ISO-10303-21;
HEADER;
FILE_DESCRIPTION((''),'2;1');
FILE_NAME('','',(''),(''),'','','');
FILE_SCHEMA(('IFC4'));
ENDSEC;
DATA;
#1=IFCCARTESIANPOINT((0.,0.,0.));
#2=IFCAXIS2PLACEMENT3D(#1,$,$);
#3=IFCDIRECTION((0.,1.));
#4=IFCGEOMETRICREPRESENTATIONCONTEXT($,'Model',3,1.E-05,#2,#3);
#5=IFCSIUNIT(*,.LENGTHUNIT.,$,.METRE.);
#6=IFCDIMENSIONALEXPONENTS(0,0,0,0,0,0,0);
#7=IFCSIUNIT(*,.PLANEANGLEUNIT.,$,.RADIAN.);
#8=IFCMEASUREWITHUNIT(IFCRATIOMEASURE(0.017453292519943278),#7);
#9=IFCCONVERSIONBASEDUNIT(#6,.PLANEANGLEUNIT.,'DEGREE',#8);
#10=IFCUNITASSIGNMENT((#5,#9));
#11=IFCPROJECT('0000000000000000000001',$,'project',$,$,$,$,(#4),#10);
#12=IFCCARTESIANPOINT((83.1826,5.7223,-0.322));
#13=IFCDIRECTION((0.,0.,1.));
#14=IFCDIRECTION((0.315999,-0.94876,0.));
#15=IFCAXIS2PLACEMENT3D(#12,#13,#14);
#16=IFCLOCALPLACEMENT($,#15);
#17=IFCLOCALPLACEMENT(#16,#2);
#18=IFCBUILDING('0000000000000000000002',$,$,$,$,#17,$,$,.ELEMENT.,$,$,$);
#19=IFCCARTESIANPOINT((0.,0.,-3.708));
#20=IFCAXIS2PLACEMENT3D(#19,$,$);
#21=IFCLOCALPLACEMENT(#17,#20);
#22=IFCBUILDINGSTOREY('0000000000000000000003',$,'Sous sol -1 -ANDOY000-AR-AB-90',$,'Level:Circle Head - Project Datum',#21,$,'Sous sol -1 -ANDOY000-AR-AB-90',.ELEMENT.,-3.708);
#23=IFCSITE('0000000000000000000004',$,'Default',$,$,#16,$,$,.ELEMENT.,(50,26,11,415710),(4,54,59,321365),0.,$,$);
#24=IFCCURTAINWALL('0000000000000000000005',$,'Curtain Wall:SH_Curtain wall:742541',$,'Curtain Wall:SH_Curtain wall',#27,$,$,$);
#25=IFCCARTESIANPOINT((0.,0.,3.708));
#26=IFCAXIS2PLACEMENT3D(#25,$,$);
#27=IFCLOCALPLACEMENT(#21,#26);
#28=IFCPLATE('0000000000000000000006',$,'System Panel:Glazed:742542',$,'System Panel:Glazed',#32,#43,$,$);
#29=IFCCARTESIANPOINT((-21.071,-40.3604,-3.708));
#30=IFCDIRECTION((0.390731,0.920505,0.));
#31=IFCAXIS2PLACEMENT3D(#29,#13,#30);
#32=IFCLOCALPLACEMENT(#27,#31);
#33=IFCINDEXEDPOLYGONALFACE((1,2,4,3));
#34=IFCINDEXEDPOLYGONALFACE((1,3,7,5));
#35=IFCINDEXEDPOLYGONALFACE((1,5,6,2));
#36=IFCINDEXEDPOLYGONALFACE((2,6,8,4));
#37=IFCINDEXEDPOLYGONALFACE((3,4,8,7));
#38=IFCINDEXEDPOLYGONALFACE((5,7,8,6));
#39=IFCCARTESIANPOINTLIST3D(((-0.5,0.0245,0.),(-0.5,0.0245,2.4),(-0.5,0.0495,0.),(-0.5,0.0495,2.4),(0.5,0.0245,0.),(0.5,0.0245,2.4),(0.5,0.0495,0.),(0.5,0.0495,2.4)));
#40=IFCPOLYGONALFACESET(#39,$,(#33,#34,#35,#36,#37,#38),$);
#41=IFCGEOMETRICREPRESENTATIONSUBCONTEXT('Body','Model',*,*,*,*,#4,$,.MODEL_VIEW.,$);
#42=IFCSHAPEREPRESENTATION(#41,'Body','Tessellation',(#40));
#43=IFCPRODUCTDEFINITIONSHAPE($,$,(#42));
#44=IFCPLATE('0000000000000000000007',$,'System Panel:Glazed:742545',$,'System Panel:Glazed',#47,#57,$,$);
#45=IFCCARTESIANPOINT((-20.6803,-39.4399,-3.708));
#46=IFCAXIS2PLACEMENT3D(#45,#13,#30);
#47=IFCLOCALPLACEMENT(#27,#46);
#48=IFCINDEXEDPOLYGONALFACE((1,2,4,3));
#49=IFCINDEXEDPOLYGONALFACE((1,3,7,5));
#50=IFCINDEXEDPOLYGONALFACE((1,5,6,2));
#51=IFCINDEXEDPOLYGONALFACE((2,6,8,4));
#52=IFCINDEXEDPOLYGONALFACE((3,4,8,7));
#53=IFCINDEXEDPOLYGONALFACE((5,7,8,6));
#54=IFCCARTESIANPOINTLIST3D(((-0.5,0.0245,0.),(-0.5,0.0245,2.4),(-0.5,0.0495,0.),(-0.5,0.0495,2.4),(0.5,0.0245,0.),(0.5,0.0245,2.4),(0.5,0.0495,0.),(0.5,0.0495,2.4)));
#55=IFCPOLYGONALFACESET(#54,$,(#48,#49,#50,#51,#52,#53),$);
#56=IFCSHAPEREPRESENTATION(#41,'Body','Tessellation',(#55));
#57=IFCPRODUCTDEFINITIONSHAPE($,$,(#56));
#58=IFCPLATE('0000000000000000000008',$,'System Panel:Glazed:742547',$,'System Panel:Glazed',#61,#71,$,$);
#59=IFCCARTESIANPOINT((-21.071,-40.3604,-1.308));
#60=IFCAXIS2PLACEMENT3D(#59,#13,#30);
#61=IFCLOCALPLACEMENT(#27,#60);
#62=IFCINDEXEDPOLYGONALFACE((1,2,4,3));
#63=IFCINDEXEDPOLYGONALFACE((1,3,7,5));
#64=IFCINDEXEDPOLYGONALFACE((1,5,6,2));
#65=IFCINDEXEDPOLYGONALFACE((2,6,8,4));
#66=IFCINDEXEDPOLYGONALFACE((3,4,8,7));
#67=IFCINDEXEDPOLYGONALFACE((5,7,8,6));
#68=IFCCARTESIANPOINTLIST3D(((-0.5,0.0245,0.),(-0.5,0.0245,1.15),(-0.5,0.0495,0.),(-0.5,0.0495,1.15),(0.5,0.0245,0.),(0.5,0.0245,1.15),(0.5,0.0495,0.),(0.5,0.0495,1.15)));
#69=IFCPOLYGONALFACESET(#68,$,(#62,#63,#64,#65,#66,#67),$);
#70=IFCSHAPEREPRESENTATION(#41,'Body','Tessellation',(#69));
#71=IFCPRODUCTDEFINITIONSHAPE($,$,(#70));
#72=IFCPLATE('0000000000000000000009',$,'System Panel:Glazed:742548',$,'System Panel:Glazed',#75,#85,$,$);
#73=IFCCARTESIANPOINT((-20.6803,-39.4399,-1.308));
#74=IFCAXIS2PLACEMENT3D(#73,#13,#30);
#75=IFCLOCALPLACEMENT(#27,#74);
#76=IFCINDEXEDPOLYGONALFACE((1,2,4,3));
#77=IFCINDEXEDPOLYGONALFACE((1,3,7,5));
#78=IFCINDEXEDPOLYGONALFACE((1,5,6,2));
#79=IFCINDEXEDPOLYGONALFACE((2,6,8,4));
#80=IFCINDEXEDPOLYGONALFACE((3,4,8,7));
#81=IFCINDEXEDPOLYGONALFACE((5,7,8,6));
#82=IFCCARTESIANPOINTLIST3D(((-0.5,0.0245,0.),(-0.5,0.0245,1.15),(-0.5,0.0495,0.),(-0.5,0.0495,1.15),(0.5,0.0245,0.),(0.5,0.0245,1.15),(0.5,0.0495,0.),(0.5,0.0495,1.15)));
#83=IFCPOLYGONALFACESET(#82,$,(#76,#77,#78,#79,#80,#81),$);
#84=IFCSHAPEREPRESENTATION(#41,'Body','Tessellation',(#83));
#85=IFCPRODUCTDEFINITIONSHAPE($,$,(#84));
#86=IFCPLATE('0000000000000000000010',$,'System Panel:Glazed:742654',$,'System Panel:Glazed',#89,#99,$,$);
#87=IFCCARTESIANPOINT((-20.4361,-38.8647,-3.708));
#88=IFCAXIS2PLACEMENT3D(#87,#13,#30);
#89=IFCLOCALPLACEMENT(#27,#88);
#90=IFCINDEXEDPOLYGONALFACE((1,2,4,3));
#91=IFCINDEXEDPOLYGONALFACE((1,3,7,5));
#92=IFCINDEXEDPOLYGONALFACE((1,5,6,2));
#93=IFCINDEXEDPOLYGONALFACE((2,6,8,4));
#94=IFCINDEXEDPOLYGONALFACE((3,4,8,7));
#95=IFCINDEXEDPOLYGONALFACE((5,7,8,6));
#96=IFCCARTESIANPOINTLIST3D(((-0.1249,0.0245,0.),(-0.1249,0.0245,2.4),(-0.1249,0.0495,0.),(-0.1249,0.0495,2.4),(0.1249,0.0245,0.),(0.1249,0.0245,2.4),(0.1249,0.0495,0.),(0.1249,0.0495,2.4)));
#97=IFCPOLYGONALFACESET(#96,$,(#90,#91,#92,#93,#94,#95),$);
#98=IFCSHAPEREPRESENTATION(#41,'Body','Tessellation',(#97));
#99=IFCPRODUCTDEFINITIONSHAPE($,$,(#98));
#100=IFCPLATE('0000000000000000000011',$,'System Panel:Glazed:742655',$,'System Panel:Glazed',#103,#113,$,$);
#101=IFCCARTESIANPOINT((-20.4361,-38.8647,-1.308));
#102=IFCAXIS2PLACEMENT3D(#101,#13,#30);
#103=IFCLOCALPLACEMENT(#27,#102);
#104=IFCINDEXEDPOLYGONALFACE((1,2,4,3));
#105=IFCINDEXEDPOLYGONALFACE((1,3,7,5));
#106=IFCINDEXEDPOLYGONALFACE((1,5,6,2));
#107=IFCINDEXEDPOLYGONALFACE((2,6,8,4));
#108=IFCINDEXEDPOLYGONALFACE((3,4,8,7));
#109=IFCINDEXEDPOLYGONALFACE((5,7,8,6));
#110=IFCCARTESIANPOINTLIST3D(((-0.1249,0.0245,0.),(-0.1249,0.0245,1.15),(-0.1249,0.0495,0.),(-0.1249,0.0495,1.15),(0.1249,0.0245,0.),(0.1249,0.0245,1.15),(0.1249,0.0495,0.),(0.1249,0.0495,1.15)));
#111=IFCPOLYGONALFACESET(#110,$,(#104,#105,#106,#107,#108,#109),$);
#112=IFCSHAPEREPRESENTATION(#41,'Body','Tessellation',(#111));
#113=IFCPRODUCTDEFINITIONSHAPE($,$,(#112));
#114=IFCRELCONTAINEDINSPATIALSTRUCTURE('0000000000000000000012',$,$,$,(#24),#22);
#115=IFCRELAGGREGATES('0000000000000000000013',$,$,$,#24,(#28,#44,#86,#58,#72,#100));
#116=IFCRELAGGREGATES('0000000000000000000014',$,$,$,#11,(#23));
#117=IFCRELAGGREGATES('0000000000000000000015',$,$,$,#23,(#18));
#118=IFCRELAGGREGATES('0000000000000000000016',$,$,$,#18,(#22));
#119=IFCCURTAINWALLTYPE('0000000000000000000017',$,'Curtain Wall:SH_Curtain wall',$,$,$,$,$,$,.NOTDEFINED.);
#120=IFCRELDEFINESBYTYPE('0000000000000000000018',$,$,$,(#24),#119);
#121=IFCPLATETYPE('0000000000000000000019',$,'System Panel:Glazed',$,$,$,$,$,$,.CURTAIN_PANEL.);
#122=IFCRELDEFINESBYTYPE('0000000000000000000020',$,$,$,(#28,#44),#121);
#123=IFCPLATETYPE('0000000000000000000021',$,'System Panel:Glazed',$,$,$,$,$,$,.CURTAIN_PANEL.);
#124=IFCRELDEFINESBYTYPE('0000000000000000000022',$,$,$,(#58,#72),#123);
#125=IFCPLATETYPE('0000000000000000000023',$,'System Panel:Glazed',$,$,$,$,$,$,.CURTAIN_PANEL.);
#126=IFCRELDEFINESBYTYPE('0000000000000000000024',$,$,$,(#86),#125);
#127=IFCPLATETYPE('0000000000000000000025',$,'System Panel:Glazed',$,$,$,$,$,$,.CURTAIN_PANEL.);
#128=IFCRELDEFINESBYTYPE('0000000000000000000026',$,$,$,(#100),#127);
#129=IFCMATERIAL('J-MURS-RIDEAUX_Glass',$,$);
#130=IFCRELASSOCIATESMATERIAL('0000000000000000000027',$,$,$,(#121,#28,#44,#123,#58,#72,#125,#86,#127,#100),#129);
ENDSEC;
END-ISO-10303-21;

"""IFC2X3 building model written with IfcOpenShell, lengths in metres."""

from ifc_helpers import new_model, entity, si_unit, converted_unit, direction, frame, frame_2d, origin, origin_2d_with_axis, place, context, subcontext, project, spatial, rectangle, extrude, source, transform, mapped, material, type_object, type_shapes, element, aggregate, save


model = new_model("IFC2X3")

# Units and contexts
model_context = context("Model", 3, precision=1e-05, world=origin(), true_north=direction((0.0, 1.0)))
body_context = subcontext(model_context, "Body", "Model", "MODEL_VIEW")
ifc_project = project(units=[si_unit("LENGTHUNIT", "METRE"), converted_unit("PLANEANGLEUNIT", "DEGREE", entity("IfcRatioMeasure", 0.017453292519943278), si_unit("PLANEANGLEUNIT", "RADIAN"), dimensions=[0, 0, 0, 0, 0, 0, 0])], contexts=[model_context])

# Site, building, storey
site_placement = place(None, frame((83.1826, 5.7223, -0.322), z_axis=(0.0, 0.0, 1.0), x_axis=(0.315999, -0.94876, 0.0)))
site = spatial("IfcSite", under=ifc_project, at=site_placement, Name="Default", CompositionType="ELEMENT", RefLatitude=(50, 26, 11, 415710), RefLongitude=(4, 54, 59, 321365), RefElevation=0.0)
building_placement = place(site_placement, origin())
building = spatial("IfcBuilding", under=site, at=building_placement, CompositionType="ELEMENT")
storey_placement = place(building_placement, frame((0.0, 0.0, -3.708)))
storey = spatial("IfcBuildingStorey", under=building, at=storey_placement, Name="Sous sol -1 -ANDOY000-AR-AB-90", ObjectType="Level:Circle Head - Project Datum", LongName="Sous sol -1 -ANDOY000-AR-AB-90", CompositionType="ELEMENT", Elevation=-3.708)

# Curtain wall, plates
curtain_wall_type = type_object("IfcCurtainWallType", Name="Curtain Wall:SH_Curtain wall", PredefinedType="NOTDEFINED")
curtain_wall_placement = place(storey_placement, frame((0.0, 0.0, 3.708)))
curtain_wall = element("IfcCurtainWall", 1, at=curtain_wall_placement, inside=storey, type_object=curtain_wall_type, Name="Curtain Wall:SH_Curtain wall:742541", ObjectType="Curtain Wall:SH_Curtain wall")
ifc_material_1 = material(Name="J-MURS-RIDEAUX_Glass")
plate_type_1 = type_object("IfcPlateType", Name="System Panel:Glazed", PredefinedType="CURTAIN_PANEL", material=ifc_material_1)
shared_shape_1 = source(origin(), body_context, "Body", "SweptSolid", [
    extrude(rectangle(XDim=0.025, YDim=1.0, at=frame_2d((0.0, 0.0), x_axis=(1.0, 0.0))), frame((0.0, 0.037, 0.0), z_axis=(0.0, 0.0, 1.0), x_axis=(0.0, 1.0, 0.0)), (0.0, 0.0, 1.0), 2.4),
])
type_shapes(plate_type_1, [shared_shape_1])
plate_1_placement = place(curtain_wall_placement, frame((-21.071, -40.3604, -3.708), z_axis=(0.0, 0.0, 1.0), x_axis=(0.390731, 0.920505, 0.0)))
plate_1 = element("IfcPlate", 2, at=plate_1_placement, type_object=plate_type_1, material=ifc_material_1, Name="System Panel:Glazed:742542", ObjectType="System Panel:Glazed", context=body_context, shape_type="MappedRepresentation", body=[
    mapped(shared_shape_1, transform((0.0, 0.0, 0.0), scale=1.0)),
])
plate_2_placement = place(curtain_wall_placement, frame((-20.6803, -39.4399, -3.708), z_axis=(0.0, 0.0, 1.0), x_axis=(0.390731, 0.920505, 0.0)))
plate_2 = element("IfcPlate", 3, at=plate_2_placement, type_object=plate_type_1, material=ifc_material_1, Name="System Panel:Glazed:742545", ObjectType="System Panel:Glazed", context=body_context, shape_type="MappedRepresentation", body=[
    mapped(shared_shape_1, transform((0.0, 0.0, 0.0), scale=1.0)),
])
plate_type_2 = type_object("IfcPlateType", Name="System Panel:Glazed", PredefinedType="CURTAIN_PANEL", material=ifc_material_1)
shared_shape_2 = source(origin(), body_context, "Body", "SweptSolid", [
    extrude(rectangle(XDim=0.025, YDim=1.0, at=origin_2d_with_axis()), frame((0.0, 0.037, 0.0), z_axis=(0.0, 0.0, 1.0), x_axis=(0.0, 1.0, 0.0)), (0.0, 0.0, 1.0), 1.15),
])
type_shapes(plate_type_2, [shared_shape_2])
plate_3_placement = place(curtain_wall_placement, frame((-21.071, -40.3604, -1.308), z_axis=(0.0, 0.0, 1.0), x_axis=(0.390731, 0.920505, 0.0)))
plate_3 = element("IfcPlate", 4, at=plate_3_placement, type_object=plate_type_2, material=ifc_material_1, Name="System Panel:Glazed:742547", ObjectType="System Panel:Glazed", context=body_context, shape_type="MappedRepresentation", body=[
    mapped(shared_shape_2, transform((0.0, 0.0, 0.0), scale=1.0)),
])
plate_4_placement = place(curtain_wall_placement, frame((-20.6803, -39.4399, -1.308), z_axis=(0.0, 0.0, 1.0), x_axis=(0.390731, 0.920505, 0.0)))
plate_4 = element("IfcPlate", 5, at=plate_4_placement, type_object=plate_type_2, material=ifc_material_1, Name="System Panel:Glazed:742548", ObjectType="System Panel:Glazed", context=body_context, shape_type="MappedRepresentation", body=[
    mapped(shared_shape_2, transform((0.0, 0.0, 0.0), scale=1.0)),
])
plate_type_3 = type_object("IfcPlateType", Name="System Panel:Glazed", PredefinedType="CURTAIN_PANEL", material=ifc_material_1)
shared_shape_3 = source(origin(), body_context, "Body", "SweptSolid", [
    extrude(rectangle(XDim=0.025, YDim=0.2498, at=frame_2d((0.0, 0.0), x_axis=(1.0, 0.0))), frame((0.0, 0.037, 0.0), z_axis=(0.0, 0.0, 1.0), x_axis=(0.0, 1.0, 0.0)), (0.0, 0.0, 1.0), 2.4),
])
type_shapes(plate_type_3, [shared_shape_3])
plate_5_placement = place(curtain_wall_placement, frame((-20.4361, -38.8647, -3.708), z_axis=(0.0, 0.0, 1.0), x_axis=(0.390731, 0.920505, 0.0)))
plate_5 = element("IfcPlate", 6, at=plate_5_placement, type_object=plate_type_3, material=ifc_material_1, Name="System Panel:Glazed:742654", ObjectType="System Panel:Glazed", context=body_context, shape_type="MappedRepresentation", body=[
    mapped(shared_shape_3, transform((0.0, 0.0, 0.0), scale=1.0)),
])
plate_type_4 = type_object("IfcPlateType", Name="System Panel:Glazed", PredefinedType="CURTAIN_PANEL", material=ifc_material_1)
shared_shape_4 = source(origin(), body_context, "Body", "SweptSolid", [
    extrude(rectangle(XDim=0.025, YDim=0.2498, at=frame_2d((0.0, 0.0), x_axis=(1.0, 0.0))), frame((0.0, 0.037, 0.0), z_axis=(0.0, 0.0, 1.0), x_axis=(0.0, 1.0, 0.0)), (0.0, 0.0, 1.0), 1.15),
])
type_shapes(plate_type_4, [shared_shape_4])
plate_6_placement = place(curtain_wall_placement, frame((-20.4361, -38.8647, -1.308), z_axis=(0.0, 0.0, 1.0), x_axis=(0.390731, 0.920505, 0.0)))
plate_6 = element("IfcPlate", 7, at=plate_6_placement, type_object=plate_type_4, material=ifc_material_1, Name="System Panel:Glazed:742655", ObjectType="System Panel:Glazed", context=body_context, shape_type="MappedRepresentation", body=[
    mapped(shared_shape_4, transform((0.0, 0.0, 0.0), scale=1.0)),
])
aggregate(curtain_wall, [plate_1, plate_2, plate_5, plate_3, plate_4, plate_6])

save(model, "model.ifc")
